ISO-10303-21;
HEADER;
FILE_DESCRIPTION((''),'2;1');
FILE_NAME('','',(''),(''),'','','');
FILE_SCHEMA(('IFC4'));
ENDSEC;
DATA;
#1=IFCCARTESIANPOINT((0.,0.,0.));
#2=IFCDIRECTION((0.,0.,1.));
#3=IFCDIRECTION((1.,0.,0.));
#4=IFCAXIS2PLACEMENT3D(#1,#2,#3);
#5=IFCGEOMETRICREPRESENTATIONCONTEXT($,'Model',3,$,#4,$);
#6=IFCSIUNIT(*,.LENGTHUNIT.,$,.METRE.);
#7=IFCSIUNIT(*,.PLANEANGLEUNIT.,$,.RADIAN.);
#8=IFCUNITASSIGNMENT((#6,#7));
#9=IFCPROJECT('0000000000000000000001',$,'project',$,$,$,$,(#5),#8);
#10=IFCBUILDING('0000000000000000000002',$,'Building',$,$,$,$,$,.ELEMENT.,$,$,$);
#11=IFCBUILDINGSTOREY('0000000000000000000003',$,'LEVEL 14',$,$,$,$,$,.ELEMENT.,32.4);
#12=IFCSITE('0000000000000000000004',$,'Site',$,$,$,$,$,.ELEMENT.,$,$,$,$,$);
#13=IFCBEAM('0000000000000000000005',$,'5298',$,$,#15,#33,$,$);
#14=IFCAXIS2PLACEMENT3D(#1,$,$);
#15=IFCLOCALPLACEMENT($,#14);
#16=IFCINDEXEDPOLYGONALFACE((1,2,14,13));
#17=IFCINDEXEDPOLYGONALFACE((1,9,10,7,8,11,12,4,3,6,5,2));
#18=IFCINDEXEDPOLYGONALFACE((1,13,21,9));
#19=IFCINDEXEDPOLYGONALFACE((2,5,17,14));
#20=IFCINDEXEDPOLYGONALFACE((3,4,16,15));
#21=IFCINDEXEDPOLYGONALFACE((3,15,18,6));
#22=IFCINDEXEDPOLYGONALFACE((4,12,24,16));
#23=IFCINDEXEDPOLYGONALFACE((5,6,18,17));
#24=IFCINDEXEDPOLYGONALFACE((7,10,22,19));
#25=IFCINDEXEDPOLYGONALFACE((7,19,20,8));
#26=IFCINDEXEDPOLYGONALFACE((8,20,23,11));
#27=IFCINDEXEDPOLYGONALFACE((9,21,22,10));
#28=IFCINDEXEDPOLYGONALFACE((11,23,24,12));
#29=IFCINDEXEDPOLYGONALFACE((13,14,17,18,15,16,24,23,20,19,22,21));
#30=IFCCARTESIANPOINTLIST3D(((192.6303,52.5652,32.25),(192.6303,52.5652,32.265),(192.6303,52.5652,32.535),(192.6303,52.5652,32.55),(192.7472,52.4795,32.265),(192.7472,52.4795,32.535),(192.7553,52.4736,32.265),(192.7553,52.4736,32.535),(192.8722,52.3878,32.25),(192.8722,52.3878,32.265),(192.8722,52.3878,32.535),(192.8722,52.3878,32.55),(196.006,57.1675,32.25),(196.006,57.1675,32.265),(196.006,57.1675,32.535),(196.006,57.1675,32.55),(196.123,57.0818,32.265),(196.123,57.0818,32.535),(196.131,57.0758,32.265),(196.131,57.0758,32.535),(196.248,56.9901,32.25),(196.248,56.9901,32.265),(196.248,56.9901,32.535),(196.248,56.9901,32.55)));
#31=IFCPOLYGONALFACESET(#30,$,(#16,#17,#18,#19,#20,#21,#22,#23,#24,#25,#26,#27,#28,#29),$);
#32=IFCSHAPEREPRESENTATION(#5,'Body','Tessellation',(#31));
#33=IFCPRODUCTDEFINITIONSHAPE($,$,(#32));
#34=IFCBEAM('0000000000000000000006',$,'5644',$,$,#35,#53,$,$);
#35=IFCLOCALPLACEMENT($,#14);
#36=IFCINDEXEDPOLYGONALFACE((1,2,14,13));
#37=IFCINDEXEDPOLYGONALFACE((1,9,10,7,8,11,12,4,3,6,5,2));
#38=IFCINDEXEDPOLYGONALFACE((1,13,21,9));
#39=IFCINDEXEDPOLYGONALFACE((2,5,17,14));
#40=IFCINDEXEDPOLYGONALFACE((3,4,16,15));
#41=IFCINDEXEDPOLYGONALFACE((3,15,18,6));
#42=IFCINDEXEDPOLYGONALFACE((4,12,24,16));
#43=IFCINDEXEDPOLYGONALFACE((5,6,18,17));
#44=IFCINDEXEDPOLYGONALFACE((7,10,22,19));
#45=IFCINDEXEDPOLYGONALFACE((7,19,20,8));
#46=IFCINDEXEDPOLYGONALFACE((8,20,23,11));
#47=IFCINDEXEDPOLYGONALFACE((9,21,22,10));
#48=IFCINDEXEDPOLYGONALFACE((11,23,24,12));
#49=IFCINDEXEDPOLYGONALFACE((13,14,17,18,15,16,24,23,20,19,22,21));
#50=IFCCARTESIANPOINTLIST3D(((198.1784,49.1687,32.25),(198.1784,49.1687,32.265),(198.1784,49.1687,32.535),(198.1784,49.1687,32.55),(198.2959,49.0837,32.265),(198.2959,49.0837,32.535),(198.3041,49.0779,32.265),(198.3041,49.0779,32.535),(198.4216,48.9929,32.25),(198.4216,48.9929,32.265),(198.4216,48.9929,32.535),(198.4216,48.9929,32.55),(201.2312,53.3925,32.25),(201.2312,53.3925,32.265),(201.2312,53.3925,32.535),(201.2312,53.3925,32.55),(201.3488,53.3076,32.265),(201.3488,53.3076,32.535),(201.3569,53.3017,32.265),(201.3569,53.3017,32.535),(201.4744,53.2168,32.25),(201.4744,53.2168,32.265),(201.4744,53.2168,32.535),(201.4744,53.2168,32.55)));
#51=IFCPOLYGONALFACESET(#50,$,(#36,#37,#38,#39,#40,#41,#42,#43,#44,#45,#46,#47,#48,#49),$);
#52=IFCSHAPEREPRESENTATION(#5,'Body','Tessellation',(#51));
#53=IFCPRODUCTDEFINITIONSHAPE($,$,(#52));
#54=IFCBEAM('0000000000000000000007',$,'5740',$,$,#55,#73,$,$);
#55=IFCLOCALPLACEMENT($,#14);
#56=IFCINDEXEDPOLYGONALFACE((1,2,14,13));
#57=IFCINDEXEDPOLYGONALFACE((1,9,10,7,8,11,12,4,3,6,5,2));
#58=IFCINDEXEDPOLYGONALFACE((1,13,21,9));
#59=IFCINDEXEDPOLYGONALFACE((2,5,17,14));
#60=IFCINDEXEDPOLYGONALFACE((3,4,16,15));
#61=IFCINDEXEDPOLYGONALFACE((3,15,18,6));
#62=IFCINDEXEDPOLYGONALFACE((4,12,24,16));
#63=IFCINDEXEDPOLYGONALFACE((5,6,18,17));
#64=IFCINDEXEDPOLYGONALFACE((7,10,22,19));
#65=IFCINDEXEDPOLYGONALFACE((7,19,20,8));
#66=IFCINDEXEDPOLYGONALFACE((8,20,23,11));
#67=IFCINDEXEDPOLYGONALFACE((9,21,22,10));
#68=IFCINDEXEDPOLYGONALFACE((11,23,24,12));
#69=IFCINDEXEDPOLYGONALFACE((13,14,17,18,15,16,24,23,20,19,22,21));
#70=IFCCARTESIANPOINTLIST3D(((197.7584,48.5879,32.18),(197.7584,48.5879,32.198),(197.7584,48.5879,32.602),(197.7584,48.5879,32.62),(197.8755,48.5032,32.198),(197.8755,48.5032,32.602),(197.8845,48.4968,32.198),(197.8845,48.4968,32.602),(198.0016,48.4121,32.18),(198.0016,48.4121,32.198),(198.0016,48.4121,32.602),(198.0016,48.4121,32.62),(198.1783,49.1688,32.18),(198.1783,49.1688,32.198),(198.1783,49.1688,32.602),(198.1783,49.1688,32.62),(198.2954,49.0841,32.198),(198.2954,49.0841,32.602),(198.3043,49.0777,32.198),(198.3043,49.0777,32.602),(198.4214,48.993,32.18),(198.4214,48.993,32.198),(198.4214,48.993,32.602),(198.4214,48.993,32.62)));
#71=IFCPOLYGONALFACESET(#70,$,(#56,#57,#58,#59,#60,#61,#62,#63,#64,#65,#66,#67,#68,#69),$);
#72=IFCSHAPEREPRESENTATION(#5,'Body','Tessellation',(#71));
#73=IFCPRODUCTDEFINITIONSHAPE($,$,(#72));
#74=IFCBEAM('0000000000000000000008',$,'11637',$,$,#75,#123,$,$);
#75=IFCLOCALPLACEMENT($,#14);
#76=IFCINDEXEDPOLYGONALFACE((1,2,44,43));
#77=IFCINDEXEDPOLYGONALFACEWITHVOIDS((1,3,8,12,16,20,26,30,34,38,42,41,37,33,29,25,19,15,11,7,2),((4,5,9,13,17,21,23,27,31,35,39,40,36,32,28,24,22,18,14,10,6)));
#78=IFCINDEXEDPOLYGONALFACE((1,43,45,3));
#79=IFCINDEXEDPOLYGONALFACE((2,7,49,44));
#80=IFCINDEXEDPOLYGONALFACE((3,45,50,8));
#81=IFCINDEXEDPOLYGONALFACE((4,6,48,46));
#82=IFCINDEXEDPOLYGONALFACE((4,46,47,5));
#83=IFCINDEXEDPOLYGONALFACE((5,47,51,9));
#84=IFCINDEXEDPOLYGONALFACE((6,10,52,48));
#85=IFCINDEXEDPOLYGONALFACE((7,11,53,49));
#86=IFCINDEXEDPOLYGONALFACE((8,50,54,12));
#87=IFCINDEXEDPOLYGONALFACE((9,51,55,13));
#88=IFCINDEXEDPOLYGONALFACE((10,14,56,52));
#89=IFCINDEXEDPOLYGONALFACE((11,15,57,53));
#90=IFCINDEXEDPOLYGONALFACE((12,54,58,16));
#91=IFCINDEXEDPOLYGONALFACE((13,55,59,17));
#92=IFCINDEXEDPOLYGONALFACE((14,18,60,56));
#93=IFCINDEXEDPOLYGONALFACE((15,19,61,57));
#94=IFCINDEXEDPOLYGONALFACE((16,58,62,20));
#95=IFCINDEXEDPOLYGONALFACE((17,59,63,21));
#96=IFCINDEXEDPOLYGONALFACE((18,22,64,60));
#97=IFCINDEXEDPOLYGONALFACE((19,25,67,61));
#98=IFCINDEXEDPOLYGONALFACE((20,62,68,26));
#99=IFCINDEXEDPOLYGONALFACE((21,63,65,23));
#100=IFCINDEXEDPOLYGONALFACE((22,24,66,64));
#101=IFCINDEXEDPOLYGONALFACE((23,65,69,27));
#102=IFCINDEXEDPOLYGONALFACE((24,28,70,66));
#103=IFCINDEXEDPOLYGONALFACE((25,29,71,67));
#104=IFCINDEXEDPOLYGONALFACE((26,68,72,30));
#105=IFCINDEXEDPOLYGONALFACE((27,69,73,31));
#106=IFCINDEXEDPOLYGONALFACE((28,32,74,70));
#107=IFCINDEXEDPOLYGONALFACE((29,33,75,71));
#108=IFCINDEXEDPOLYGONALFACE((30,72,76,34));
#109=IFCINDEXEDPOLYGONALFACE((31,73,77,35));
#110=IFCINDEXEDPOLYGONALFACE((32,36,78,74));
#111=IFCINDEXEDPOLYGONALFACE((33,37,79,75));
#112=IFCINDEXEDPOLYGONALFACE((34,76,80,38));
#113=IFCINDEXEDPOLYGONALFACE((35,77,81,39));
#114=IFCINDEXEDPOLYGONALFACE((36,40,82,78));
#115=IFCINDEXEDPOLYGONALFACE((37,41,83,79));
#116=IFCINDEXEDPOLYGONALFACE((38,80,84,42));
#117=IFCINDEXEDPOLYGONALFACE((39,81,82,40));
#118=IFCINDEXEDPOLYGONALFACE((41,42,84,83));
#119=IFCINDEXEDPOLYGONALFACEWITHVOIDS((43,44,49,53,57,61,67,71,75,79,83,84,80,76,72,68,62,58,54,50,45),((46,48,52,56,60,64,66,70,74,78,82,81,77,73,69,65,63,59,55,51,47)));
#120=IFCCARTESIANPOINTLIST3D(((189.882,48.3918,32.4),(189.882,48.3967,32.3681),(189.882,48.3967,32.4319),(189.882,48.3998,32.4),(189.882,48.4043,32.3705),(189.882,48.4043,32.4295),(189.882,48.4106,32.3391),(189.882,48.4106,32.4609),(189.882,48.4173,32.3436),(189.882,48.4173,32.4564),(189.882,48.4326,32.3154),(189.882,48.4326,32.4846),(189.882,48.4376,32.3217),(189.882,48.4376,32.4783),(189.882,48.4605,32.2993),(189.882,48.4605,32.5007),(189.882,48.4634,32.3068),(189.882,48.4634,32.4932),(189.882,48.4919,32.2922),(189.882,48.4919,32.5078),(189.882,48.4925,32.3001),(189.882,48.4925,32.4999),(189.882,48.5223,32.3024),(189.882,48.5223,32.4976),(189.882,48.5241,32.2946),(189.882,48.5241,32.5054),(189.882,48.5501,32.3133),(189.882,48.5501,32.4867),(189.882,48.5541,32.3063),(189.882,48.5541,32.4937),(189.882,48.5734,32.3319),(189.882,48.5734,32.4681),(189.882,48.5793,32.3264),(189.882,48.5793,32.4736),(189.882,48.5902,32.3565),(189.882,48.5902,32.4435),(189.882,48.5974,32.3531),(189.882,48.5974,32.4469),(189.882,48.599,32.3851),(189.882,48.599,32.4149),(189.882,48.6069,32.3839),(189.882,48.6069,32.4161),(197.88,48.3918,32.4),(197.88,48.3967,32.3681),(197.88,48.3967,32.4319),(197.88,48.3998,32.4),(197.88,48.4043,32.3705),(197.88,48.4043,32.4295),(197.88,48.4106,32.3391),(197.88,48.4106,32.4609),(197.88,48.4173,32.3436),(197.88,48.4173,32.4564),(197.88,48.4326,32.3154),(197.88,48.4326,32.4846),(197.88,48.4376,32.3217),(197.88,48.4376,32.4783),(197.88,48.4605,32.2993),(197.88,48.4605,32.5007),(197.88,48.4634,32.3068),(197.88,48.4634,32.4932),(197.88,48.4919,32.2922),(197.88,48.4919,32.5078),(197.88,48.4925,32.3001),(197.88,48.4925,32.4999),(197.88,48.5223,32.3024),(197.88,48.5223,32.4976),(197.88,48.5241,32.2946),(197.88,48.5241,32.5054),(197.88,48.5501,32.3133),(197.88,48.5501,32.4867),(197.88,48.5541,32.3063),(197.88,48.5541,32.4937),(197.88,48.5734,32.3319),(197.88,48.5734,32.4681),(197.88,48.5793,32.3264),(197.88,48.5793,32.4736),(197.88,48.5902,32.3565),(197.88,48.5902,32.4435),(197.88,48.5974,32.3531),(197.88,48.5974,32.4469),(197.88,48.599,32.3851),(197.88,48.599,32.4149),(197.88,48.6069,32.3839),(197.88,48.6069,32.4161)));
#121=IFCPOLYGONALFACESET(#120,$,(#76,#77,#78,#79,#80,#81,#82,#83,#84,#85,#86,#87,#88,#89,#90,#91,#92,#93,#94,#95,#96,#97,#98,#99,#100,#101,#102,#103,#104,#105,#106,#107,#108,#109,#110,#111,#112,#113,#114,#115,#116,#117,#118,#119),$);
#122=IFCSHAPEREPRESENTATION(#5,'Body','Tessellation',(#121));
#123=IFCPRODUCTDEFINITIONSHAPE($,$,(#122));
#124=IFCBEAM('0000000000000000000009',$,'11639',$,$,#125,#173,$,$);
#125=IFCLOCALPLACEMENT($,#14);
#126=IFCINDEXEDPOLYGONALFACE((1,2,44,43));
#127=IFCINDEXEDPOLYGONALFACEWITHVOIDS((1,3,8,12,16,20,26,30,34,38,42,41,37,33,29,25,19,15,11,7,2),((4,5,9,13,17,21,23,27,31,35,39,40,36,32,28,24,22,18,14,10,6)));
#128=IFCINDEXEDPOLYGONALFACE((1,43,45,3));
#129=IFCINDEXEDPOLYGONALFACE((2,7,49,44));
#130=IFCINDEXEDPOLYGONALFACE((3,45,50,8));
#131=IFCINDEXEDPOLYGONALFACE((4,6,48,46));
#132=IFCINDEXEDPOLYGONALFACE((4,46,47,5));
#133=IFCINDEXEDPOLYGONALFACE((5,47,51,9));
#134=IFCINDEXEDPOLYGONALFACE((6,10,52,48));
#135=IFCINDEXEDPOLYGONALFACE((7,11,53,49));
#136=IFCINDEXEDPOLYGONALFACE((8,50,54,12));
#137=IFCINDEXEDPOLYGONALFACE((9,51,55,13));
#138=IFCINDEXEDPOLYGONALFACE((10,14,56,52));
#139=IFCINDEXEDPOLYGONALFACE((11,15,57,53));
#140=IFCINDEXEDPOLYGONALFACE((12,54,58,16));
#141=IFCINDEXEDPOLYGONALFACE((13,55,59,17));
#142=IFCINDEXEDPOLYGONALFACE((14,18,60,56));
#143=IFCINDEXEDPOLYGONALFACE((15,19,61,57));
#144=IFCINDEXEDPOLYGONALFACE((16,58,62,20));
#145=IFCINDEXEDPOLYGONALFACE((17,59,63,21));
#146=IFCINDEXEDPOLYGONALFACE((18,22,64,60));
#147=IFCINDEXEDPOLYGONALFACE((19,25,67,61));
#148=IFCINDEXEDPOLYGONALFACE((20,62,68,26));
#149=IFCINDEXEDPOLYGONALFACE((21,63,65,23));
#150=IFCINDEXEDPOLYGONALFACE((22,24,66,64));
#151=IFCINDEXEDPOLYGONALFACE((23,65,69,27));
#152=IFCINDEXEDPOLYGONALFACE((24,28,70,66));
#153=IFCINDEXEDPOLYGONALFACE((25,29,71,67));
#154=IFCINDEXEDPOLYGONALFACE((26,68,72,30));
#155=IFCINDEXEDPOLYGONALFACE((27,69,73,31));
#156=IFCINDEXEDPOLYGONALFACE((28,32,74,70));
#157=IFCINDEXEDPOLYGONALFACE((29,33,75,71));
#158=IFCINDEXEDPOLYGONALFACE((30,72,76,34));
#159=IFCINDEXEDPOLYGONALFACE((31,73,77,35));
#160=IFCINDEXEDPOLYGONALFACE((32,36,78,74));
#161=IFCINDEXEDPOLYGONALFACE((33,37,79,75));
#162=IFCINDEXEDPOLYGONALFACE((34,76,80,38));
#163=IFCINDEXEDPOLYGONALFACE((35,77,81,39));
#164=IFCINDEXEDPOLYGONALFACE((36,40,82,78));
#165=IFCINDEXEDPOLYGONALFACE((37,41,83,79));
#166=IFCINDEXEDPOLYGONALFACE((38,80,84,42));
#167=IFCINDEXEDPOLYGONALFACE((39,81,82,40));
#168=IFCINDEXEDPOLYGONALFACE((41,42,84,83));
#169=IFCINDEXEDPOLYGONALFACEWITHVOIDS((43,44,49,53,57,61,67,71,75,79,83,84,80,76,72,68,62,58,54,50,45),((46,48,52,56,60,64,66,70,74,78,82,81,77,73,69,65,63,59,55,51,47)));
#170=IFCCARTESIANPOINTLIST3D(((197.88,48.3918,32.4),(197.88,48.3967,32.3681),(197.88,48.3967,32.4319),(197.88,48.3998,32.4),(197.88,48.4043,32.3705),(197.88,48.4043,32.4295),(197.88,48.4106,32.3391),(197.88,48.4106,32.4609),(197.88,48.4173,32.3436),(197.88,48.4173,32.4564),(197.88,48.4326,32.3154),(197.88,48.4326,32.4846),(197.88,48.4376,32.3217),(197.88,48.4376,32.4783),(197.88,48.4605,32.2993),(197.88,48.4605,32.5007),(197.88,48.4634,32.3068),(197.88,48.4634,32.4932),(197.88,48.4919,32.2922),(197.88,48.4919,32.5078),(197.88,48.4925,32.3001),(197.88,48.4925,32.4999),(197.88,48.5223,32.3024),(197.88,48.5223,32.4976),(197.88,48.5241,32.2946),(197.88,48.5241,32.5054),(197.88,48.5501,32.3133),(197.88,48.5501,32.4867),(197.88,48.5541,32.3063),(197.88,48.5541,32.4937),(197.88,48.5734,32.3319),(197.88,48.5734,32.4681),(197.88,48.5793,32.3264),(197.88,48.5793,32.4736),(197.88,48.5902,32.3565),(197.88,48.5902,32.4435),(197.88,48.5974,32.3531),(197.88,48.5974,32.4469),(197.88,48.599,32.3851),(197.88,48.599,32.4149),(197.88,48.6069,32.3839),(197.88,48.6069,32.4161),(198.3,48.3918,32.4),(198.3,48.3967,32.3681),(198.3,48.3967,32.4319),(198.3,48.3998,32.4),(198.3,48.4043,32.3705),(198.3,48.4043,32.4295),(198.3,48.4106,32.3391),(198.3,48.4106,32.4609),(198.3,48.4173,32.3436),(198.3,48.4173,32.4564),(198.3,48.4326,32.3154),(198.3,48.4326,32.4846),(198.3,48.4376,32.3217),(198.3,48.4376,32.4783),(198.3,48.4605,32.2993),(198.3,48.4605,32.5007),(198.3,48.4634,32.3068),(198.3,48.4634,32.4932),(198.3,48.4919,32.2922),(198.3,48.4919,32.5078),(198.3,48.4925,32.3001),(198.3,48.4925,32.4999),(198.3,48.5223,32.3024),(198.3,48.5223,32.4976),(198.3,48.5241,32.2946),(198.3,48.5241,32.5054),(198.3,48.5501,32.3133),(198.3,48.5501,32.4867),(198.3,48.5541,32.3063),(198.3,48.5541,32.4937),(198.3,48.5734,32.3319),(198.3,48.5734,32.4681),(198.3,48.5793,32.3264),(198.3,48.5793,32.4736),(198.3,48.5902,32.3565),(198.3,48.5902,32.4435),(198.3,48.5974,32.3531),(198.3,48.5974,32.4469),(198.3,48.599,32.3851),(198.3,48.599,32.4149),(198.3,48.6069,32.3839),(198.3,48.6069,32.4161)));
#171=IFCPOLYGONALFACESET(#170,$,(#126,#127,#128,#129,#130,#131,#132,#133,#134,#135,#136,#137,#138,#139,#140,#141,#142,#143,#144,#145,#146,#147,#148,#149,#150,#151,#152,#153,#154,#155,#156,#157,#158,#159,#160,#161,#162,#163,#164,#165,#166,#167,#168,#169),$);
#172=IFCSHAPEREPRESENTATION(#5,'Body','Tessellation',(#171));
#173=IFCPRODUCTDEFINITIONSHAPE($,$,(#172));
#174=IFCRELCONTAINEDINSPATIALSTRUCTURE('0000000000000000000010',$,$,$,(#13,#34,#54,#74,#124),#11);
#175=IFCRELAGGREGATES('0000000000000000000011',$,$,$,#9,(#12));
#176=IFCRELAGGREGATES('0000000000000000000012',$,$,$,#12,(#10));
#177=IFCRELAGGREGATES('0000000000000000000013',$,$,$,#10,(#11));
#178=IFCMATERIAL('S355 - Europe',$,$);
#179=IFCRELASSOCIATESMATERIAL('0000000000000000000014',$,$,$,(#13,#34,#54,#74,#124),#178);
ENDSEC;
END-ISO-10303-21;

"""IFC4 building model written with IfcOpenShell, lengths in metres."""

from ifc_helpers import new_model, si_unit, frame, origin_with_axes, origin_2d_with_axis, place, context, project, spatial, hollow_circle, i_section, extrude, material, material_profile, profile_set, profile_usage, element, save


model = new_model("IFC4")

# Units and contexts
model_context = context("Model", 3, world=origin_with_axes())
ifc_project = project(units=[si_unit("LENGTHUNIT", "METRE"), si_unit("PLANEANGLEUNIT", "RADIAN")], contexts=[model_context])

# Site, building, storey
site = spatial("IfcSite", under=ifc_project, Name="Site", CompositionType="ELEMENT")
building = spatial("IfcBuilding", under=site, Name="Building", CompositionType="ELEMENT")
storey = spatial("IfcBuildingStorey", under=building, Name="LEVEL 14", CompositionType="ELEMENT", Elevation=32.4)

# Shared definitions
ifc_material = material(Name="S355 - Europe")

# Beams
ifc_material_profile_1 = material_profile(ifc_material, i_section(OverallWidth=0.3, OverallDepth=0.3, WebThickness=0.01, FlangeThickness=0.015, at=origin_2d_with_axis()))
ifc_profile_set_1 = profile_set([ifc_material_profile_1])
ifc_profile_usage_1 = profile_usage(ifc_profile_set_1, cardinal=10)
beam_1_placement = place(None, frame((196.127, 57.0788, 32.4), z_axis=(-0.591449, -0.806343, 0.0), x_axis=(0.805899, -0.592052, 0.0)))
element("IfcBeam", 1, at=beam_1_placement, inside=storey, material=ifc_profile_usage_1, Name="5298", context=model_context, shape_type="SweptSolid", body=[
    extrude(i_section(OverallWidth=0.3, OverallDepth=0.3, WebThickness=0.01, FlangeThickness=0.015, at=origin_2d_with_axis()), origin_with_axes(), (0.0, 0.0, 1.0), 5.7076),
])
ifc_material_profile_2 = material_profile(ifc_material, i_section(OverallWidth=0.3, OverallDepth=0.3, WebThickness=0.01, FlangeThickness=0.015, at=origin_2d_with_axis()))
ifc_profile_set_2 = profile_set([ifc_material_profile_2])
ifc_profile_usage_2 = profile_usage(ifc_profile_set_2, cardinal=10)
beam_2_placement = place(None, frame((198.3, 49.0808, 32.4), z_axis=(0.585773, 0.810475, 0.0), x_axis=(-0.810441, 0.585821, 0.0)))
element("IfcBeam", 2, at=beam_2_placement, inside=storey, material=ifc_profile_usage_2, Name="5644", context=model_context, shape_type="SweptSolid", body=[
    extrude(i_section(OverallWidth=0.3, OverallDepth=0.3, WebThickness=0.01, FlangeThickness=0.015, at=origin_2d_with_axis()), origin_with_axes(), (0.0, 0.0, 1.0), 5.2116),
])
ifc_material_profile_3 = material_profile(ifc_material, i_section(OverallWidth=0.3, OverallDepth=0.44, WebThickness=0.011, FlangeThickness=0.018, at=origin_2d_with_axis()))
ifc_profile_set_3 = profile_set([ifc_material_profile_3])
ifc_profile_usage_3 = profile_usage(ifc_profile_set_3, cardinal=10)
beam_3_placement = place(None, frame((197.88, 48.5, 32.4), z_axis=(0.585773, 0.810475, 0.0), x_axis=(-0.810441, 0.585821, 0.0)))
element("IfcBeam", 3, at=beam_3_placement, inside=storey, material=ifc_profile_usage_3, Name="5740", context=model_context, shape_type="SweptSolid", body=[
    extrude(i_section(OverallWidth=0.3, OverallDepth=0.44, WebThickness=0.011, FlangeThickness=0.018, at=origin_2d_with_axis()), origin_with_axes(), (0.0, 0.0, 1.0), 0.7167),
])
ifc_material_profile_4 = material_profile(ifc_material, hollow_circle(Radius=0.1081, WallThickness=0.008, at=origin_2d_with_axis()))
ifc_profile_set_4 = profile_set([ifc_material_profile_4])
ifc_profile_usage_4 = profile_usage(ifc_profile_set_4, cardinal=10)
beam_4_placement = place(None, frame((197.88, 48.5, 32.4), z_axis=(-1.0, 0.0, 0.0), x_axis=(0.0, -1.0, 0.0)))
element("IfcBeam", 4, at=beam_4_placement, inside=storey, material=ifc_profile_usage_4, Name="11637", context=model_context, shape_type="SweptSolid", body=[
    extrude(hollow_circle(Radius=0.1081, WallThickness=0.008, at=origin_2d_with_axis()), origin_with_axes(), (0.0, 0.0, 1.0), 7.998),
])
ifc_material_profile_5 = material_profile(ifc_material, hollow_circle(Radius=0.1081, WallThickness=0.008, at=origin_2d_with_axis()))
ifc_profile_set_5 = profile_set([ifc_material_profile_5])
ifc_profile_usage_5 = profile_usage(ifc_profile_set_5, cardinal=10)
beam_5_placement = place(None, frame((198.3, 48.5, 32.4), z_axis=(-1.0, 0.0, 0.0), x_axis=(0.0, -1.0, 0.0)))
element("IfcBeam", 5, at=beam_5_placement, inside=storey, material=ifc_profile_usage_5, Name="11639", context=model_context, shape_type="SweptSolid", body=[
    extrude(hollow_circle(Radius=0.1081, WallThickness=0.008, at=origin_2d_with_axis()), origin_with_axes(), (0.0, 0.0, 1.0), 0.42),
])

save(model, "model.ifc")
